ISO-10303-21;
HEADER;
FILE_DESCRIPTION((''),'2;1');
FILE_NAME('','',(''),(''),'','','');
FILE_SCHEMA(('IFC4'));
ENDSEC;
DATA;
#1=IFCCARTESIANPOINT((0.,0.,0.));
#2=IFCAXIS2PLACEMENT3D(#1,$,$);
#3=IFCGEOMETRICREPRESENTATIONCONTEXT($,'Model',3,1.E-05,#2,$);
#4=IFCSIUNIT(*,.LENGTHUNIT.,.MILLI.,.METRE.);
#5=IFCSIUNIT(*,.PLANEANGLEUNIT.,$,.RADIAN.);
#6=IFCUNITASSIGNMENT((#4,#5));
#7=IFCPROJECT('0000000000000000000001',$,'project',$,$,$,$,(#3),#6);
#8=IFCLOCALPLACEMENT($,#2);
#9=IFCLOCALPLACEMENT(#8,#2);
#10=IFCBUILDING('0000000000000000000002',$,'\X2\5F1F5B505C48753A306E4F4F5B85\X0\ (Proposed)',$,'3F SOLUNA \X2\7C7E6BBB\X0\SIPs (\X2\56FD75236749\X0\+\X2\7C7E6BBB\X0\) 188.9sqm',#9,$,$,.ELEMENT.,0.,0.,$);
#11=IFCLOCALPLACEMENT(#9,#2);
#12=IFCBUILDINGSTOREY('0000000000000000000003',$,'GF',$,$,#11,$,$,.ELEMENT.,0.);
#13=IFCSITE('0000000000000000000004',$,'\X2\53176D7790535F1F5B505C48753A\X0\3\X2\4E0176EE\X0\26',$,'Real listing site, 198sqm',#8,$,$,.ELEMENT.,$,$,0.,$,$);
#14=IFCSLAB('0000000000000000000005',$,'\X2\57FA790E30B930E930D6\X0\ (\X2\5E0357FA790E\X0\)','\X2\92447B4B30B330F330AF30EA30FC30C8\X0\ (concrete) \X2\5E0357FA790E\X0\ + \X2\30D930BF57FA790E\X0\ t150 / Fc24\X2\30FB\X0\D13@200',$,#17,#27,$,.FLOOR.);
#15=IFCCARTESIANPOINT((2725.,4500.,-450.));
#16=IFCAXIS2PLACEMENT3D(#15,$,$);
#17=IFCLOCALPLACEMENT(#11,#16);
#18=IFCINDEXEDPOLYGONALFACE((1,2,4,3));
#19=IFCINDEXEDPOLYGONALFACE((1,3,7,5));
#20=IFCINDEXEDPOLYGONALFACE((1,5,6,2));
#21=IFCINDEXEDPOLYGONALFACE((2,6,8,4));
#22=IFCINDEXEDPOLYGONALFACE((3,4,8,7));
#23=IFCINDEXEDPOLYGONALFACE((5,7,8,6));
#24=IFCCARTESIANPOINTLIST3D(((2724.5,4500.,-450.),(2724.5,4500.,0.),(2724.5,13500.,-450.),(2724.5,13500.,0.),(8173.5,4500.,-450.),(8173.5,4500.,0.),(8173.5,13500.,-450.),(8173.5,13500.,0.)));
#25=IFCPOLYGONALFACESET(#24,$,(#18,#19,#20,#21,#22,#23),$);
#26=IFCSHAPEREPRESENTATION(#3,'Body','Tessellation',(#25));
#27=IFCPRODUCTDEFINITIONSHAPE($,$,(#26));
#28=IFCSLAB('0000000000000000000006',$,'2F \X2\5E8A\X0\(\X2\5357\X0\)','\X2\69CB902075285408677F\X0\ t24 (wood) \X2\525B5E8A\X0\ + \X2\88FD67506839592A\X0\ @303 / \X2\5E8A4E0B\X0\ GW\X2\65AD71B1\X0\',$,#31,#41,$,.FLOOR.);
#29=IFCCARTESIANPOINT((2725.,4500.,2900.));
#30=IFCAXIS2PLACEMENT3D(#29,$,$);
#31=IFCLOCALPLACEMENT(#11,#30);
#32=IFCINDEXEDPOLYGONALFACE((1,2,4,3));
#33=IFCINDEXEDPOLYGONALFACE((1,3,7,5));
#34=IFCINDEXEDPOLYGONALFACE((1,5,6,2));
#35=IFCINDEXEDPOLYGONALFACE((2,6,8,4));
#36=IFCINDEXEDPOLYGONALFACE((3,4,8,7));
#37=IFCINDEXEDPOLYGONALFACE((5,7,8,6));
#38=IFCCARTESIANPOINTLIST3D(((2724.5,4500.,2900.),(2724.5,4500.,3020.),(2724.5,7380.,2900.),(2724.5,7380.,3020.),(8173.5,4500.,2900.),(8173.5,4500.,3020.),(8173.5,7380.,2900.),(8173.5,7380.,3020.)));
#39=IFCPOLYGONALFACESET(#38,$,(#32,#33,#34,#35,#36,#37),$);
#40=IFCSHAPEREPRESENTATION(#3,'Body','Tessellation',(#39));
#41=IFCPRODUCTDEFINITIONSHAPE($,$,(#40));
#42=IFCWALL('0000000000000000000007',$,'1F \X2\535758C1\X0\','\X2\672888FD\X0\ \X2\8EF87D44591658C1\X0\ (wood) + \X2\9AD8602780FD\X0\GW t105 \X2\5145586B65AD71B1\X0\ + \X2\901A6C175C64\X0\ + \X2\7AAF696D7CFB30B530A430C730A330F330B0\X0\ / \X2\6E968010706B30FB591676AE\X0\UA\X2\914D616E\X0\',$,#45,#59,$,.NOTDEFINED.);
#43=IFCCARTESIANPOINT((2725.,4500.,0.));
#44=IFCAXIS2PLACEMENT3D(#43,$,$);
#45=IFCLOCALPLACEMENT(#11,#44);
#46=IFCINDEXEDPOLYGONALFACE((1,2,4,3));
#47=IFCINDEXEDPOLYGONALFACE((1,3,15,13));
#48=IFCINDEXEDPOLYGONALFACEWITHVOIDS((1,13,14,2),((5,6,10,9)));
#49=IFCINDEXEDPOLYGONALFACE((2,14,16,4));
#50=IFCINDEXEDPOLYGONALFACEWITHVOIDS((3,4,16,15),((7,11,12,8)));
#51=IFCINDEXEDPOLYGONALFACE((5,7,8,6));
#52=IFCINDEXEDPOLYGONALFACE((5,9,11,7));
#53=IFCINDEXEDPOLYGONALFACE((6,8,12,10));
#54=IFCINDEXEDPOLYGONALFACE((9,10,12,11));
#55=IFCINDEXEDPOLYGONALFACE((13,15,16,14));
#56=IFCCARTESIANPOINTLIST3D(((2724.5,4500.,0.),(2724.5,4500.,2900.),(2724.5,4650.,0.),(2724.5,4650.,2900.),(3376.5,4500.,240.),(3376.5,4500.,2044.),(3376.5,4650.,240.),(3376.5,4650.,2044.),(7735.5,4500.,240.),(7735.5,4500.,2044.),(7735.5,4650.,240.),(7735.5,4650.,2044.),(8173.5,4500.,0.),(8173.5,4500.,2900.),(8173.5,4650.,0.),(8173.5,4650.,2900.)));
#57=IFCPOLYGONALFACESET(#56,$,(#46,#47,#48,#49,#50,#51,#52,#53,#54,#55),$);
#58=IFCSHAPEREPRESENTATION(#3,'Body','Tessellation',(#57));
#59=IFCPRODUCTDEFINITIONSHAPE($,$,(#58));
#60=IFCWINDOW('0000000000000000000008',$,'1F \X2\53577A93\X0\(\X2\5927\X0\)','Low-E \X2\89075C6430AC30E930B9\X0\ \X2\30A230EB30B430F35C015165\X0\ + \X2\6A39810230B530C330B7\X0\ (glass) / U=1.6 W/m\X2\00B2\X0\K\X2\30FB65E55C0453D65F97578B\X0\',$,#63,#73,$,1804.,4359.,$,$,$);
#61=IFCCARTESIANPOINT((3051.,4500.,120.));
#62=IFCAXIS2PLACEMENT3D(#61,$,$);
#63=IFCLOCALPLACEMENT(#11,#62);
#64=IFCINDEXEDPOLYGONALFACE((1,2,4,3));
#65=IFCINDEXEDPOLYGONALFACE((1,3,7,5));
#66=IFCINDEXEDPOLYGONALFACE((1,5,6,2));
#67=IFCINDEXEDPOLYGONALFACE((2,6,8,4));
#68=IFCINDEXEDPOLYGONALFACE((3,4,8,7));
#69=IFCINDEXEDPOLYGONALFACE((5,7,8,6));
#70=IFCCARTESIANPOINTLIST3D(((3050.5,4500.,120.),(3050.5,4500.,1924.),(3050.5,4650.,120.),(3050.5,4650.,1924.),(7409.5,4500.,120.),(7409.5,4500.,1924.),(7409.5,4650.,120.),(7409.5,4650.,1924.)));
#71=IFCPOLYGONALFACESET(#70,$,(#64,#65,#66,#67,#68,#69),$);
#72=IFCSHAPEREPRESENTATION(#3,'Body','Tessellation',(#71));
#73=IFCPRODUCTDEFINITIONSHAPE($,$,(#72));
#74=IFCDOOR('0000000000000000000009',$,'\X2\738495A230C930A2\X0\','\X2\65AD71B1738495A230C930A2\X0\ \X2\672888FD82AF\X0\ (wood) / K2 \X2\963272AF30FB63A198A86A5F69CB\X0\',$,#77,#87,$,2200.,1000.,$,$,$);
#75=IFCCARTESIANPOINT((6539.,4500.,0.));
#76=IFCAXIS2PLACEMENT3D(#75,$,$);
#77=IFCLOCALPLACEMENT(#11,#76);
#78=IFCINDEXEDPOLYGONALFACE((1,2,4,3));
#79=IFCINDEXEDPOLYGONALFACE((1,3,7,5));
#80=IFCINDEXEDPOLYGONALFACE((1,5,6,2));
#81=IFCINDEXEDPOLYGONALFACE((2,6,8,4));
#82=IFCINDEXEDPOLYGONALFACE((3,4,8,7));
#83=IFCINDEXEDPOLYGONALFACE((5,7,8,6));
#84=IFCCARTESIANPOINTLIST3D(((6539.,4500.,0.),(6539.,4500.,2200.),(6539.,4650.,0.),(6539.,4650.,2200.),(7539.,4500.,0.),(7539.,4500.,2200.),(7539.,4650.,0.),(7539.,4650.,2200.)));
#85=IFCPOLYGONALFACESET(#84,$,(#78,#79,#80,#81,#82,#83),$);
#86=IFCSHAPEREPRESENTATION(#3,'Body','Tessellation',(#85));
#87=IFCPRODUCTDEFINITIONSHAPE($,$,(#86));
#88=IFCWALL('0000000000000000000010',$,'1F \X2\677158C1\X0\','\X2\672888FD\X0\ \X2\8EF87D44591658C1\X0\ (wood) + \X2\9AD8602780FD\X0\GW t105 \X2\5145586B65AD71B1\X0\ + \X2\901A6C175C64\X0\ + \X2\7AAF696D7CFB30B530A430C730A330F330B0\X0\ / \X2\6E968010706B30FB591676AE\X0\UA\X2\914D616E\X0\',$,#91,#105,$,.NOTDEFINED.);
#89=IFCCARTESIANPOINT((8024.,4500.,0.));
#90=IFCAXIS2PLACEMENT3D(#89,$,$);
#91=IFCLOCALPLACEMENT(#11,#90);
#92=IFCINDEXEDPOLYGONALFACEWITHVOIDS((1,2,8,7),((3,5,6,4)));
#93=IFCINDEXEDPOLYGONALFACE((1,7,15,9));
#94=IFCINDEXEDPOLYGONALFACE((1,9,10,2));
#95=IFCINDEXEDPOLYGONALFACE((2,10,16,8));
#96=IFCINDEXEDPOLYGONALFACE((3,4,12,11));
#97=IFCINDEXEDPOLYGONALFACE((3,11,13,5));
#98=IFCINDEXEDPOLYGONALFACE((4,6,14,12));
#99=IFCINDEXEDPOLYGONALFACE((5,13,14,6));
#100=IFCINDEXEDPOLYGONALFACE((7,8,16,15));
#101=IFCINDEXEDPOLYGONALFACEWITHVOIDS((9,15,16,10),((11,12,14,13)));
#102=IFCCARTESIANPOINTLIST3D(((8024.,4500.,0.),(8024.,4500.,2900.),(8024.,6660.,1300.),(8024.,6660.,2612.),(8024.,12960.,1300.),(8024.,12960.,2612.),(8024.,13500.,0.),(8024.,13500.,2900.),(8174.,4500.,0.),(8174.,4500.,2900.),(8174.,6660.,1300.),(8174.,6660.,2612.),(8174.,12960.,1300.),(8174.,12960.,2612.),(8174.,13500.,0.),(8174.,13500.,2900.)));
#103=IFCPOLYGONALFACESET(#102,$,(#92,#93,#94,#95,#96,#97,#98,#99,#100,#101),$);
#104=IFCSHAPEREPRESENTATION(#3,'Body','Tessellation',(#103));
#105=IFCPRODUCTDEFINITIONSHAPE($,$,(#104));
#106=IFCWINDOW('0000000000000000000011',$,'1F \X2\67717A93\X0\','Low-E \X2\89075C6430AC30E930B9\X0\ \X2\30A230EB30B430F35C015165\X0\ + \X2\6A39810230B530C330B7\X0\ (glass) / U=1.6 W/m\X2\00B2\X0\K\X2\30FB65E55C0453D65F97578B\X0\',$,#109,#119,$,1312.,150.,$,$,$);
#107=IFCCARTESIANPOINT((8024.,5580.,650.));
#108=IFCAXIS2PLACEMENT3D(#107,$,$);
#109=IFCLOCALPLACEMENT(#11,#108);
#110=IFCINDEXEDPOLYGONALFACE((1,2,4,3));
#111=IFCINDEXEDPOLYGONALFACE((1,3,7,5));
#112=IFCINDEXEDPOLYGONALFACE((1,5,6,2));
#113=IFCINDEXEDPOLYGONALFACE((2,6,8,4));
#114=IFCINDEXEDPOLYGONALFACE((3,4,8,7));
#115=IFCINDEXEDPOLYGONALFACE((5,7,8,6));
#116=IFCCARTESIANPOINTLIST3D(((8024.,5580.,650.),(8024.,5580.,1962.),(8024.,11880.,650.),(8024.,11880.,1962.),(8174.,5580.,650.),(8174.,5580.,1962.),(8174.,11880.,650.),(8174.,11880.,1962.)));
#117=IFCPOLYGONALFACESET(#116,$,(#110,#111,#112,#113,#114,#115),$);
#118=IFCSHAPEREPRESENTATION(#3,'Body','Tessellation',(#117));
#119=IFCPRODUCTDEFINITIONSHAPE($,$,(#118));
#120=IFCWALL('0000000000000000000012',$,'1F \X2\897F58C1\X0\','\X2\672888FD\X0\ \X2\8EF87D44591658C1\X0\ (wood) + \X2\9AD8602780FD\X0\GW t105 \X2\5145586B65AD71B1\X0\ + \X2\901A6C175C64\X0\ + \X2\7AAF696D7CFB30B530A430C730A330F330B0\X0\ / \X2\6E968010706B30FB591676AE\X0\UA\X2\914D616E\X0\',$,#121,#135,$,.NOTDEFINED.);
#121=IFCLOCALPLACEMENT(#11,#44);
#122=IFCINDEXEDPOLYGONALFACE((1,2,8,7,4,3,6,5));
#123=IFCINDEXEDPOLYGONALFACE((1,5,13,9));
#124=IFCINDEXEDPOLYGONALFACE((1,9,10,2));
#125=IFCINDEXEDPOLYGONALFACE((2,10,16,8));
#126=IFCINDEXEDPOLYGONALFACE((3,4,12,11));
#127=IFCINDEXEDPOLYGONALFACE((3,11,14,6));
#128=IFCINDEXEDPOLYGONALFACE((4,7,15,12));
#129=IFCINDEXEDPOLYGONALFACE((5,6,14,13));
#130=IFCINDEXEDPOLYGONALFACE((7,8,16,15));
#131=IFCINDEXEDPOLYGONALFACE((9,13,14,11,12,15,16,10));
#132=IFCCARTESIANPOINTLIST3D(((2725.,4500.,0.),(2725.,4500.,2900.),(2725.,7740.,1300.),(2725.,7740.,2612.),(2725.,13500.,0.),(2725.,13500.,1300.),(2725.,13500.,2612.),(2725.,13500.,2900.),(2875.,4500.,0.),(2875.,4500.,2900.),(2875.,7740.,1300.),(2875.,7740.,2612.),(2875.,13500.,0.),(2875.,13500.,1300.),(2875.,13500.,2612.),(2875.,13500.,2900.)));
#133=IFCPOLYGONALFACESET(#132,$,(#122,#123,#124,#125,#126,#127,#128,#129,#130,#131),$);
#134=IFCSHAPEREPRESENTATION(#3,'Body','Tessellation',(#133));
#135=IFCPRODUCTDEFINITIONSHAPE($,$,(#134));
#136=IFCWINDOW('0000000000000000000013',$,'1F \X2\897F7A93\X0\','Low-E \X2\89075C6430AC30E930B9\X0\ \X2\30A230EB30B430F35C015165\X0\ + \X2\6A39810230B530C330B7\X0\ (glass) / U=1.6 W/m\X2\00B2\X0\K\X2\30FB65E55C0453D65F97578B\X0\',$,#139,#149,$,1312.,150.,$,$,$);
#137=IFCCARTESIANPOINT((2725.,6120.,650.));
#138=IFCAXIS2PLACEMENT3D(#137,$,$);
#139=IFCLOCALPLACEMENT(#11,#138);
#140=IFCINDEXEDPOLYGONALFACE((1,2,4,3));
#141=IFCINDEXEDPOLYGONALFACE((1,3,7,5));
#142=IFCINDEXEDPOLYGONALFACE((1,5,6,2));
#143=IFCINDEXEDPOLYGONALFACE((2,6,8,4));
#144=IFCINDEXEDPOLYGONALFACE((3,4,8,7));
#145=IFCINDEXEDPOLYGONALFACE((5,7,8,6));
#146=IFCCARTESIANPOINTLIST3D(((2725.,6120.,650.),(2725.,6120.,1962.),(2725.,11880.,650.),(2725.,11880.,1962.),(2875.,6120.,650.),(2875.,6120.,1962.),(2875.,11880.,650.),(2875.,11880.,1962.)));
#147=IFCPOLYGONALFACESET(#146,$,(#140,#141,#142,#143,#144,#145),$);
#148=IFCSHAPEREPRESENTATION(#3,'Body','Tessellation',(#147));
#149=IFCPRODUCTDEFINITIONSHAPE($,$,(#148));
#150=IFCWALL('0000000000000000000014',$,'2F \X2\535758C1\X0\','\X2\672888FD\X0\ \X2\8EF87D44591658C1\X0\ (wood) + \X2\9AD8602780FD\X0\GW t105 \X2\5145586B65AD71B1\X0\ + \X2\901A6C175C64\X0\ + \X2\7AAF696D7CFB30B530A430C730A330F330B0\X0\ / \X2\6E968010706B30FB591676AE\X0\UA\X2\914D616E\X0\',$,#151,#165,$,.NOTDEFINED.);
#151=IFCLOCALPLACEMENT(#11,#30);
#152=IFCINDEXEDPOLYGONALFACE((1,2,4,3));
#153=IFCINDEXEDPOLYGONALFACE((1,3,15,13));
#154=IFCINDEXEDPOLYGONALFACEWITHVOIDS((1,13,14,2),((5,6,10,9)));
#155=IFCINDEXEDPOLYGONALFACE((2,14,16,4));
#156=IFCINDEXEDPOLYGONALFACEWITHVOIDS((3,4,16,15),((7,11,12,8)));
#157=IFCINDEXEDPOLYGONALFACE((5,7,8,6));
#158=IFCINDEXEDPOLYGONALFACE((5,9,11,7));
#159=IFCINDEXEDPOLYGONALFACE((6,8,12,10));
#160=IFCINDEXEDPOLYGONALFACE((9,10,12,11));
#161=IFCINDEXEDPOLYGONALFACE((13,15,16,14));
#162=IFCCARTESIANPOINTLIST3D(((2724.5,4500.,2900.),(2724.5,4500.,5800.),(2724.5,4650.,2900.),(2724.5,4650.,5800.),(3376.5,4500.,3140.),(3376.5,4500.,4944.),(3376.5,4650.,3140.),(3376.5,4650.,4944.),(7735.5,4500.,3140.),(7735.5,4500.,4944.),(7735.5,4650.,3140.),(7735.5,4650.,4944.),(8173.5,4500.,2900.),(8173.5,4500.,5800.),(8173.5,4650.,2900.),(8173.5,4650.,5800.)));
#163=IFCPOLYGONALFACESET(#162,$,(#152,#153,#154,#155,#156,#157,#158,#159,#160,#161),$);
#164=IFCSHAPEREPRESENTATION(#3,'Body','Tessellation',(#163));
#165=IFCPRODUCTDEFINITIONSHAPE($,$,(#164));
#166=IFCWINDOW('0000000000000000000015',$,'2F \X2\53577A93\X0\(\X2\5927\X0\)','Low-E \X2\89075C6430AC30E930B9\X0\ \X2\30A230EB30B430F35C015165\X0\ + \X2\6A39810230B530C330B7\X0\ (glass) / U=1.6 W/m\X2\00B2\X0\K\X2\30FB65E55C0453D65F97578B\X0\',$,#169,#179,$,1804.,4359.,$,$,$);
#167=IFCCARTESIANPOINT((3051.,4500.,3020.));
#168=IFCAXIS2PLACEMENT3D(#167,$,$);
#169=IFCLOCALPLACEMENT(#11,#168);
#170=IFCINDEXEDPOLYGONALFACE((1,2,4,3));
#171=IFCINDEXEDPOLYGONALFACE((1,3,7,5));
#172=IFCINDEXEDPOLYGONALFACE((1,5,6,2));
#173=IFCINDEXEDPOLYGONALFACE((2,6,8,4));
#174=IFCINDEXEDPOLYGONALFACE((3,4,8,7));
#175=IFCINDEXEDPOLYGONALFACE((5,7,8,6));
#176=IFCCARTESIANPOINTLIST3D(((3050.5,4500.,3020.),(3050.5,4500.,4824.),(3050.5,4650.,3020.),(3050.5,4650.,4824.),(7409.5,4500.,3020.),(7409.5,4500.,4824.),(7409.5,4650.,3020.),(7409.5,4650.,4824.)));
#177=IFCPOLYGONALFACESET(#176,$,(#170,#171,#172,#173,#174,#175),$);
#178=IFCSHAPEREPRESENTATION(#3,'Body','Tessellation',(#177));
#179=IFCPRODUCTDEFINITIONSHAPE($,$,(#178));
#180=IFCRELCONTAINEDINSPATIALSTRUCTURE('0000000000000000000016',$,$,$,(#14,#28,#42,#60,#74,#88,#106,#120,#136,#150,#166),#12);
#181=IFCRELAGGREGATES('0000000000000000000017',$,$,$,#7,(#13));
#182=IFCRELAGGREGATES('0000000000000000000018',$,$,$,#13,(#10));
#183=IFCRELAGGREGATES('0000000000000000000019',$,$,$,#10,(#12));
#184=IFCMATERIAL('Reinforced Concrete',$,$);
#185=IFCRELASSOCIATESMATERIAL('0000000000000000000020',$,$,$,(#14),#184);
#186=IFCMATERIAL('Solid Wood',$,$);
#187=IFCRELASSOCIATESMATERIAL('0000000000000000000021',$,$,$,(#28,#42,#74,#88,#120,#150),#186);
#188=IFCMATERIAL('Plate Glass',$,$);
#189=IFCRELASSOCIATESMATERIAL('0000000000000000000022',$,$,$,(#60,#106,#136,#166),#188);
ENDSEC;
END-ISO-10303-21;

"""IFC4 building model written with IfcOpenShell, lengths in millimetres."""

from ifc_helpers import new_model, si_unit, frame, frame_2d, origin, place, context, project, spatial, rectangle, extrude, material, element, fill, save


model = new_model("IFC4")

# Units and contexts
model_context = context("Model", 3, precision=1e-05, world=origin())
ifc_project = project(units=[si_unit("LENGTHUNIT", "METRE", prefix="MILLI"), si_unit("PLANEANGLEUNIT", "RADIAN")], contexts=[model_context])

# Site, building, storey
site_placement = place(None, origin())
site = spatial("IfcSite", under=ifc_project, at=site_placement, Name="北海道弟子屈町3丁目26", ObjectType="Real listing site, 198sqm", CompositionType="ELEMENT", RefElevation=0.0)
building_placement = place(site_placement, origin())
building = spatial("IfcBuilding", under=site, at=building_placement, Name="弟子屈町の住宅 (Proposed)", ObjectType="3F SOLUNA 籾殻SIPs (国産杉+籾殻) 188.9sqm", CompositionType="ELEMENT", ElevationOfRefHeight=0.0, ElevationOfTerrain=0.0)
storey_placement = place(building_placement, origin())
storey = spatial("IfcBuildingStorey", under=building, at=storey_placement, Name="GF", CompositionType="ELEMENT", Elevation=0.0)

# Slabs
ifc_material_1 = material(Name="Reinforced Concrete")
slab_1_placement = place(storey_placement, frame((2725.0, 4500.0, -450.0)))
element("IfcSlab", 1, at=slab_1_placement, inside=storey, material=ifc_material_1, Name="基礎スラブ (布基礎)", Description="鉄筋コンクリート (concrete) 布基礎 + ベタ基礎 t150 / Fc24・D13@200", PredefinedType="FLOOR", context=model_context, shape_type="SweptSolid", body=[
    extrude(rectangle(XDim=5449.0, YDim=9000.0, at=frame_2d((2724.0, 4500.0))), frame((2725.0, 4500.0, -450.0)), (0.0, 0.0, 1.0), 450.0),
])
ifc_material_2 = material(Name="Solid Wood")
slab_2_placement = place(storey_placement, frame((2725.0, 4500.0, 2900.0)))
element("IfcSlab", 2, at=slab_2_placement, inside=storey, material=ifc_material_2, Name="2F 床(南)", Description="構造用合板 t24 (wood) 剛床 + 製材根太 @303 / 床下 GW断熱", PredefinedType="FLOOR", context=model_context, shape_type="SweptSolid", body=[
    extrude(rectangle(XDim=5449.0, YDim=2880.0, at=frame_2d((2724.0, 1440.0))), frame((2725.0, 4500.0, 2900.0)), (0.0, 0.0, 1.0), 120.0),
])

# Wall, openings, window, door
wall_1_placement = place(storey_placement, frame((2725.0, 4500.0, 0.0)))
wall_1 = element("IfcWall", 3, at=wall_1_placement, inside=storey, material=ifc_material_2, Name="1F 南壁", Description="木製 軸組外壁 (wood) + 高性能GW t105 充填断熱 + 通気層 + 窯業系サイディング / 準耐火・外皮UA配慮", PredefinedType="NOTDEFINED", context=model_context, shape_type="SweptSolid", body=[
    extrude(rectangle(XDim=5449.0, YDim=150.0, at=frame_2d((2724.0, 75.0))), frame((2725.0, 4500.0, 0.0)), (0.0, 0.0, 1.0), 2900.0),
])
opening_1_placement = place(storey_placement, frame((3051.0, 4500.0, 120.0)))
opening_1 = element("IfcOpeningElement", 4, at=opening_1_placement, cuts=wall_1, PredefinedType="NOTDEFINED", context=model_context, shape_type="SweptSolid", body=[
    extrude(rectangle(XDim=4359.0, YDim=150.0, at=frame_2d((2179.0, 75.0))), frame((3051.0, 4500.0, 120.0)), (0.0, 0.0, 1.0), 1804.0),
])
opening_2_placement = place(storey_placement, frame((6539.0, 4500.0, 0.0)))
opening_2 = element("IfcOpeningElement", 5, at=opening_2_placement, cuts=wall_1, PredefinedType="NOTDEFINED", context=model_context, shape_type="SweptSolid", body=[
    extrude(rectangle(XDim=1000.0, YDim=150.0, at=frame_2d((500.0, 75.0))), frame((6539.0, 4500.0, 0.0)), (0.0, 0.0, 1.0), 2200.0),
])
ifc_material_3 = material(Name="Plate Glass")
window_1_placement = place(storey_placement, frame((3051.0, 4500.0, 120.0)))
window_1 = element("IfcWindow", 6, at=window_1_placement, inside=storey, material=ifc_material_3, Name="1F 南窓(大)", Description="Low-E 複層ガラス アルゴン封入 + 樹脂サッシ (glass) / U=1.6 W/m²K・日射取得型", OverallHeight=1804.0, OverallWidth=4359.0, context=model_context, shape_type="SweptSolid", body=[
    extrude(rectangle(XDim=4359.0, YDim=150.0, at=frame_2d((2179.0, 75.0))), frame((3051.0, 4500.0, 120.0)), (0.0, 0.0, 1.0), 1804.0),
])
fill(opening_1, window_1)
door_placement = place(storey_placement, frame((6539.0, 4500.0, 0.0)))
door = element("IfcDoor", 7, at=door_placement, inside=storey, material=ifc_material_2, Name="玄関ドア", Description="断熱玄関ドア 木製芯 (wood) / K2 防犯・採風機構", OverallHeight=2200.0, OverallWidth=1000.0, context=model_context, shape_type="SweptSolid", body=[
    extrude(rectangle(XDim=1000.0, YDim=150.0, at=frame_2d((500.0, 75.0))), frame((6539.0, 4500.0, 0.0)), (0.0, 0.0, 1.0), 2200.0),
])
fill(opening_2, door)

# Walls, openings, windows
wall_2_placement = place(storey_placement, frame((8024.0, 4500.0, 0.0)))
wall_2 = element("IfcWall", 8, at=wall_2_placement, inside=storey, material=ifc_material_2, Name="1F 東壁", Description="木製 軸組外壁 (wood) + 高性能GW t105 充填断熱 + 通気層 + 窯業系サイディング / 準耐火・外皮UA配慮", PredefinedType="NOTDEFINED", context=model_context, shape_type="SweptSolid", body=[
    extrude(rectangle(XDim=150.0, YDim=9000.0, at=frame_2d((75.0, 4500.0))), frame((8024.0, 4500.0, 0.0)), (0.0, 0.0, 1.0), 2900.0),
])
opening_3_placement = place(storey_placement, frame((8024.0, 5580.0, 650.0)))
opening_3 = element("IfcOpeningElement", 9, at=opening_3_placement, cuts=wall_2, PredefinedType="NOTDEFINED", context=model_context, shape_type="SweptSolid", body=[
    extrude(rectangle(XDim=150.0, YDim=6300.0, at=frame_2d((75.0, 3150.0))), frame((8024.0, 5580.0, 650.0)), (0.0, 0.0, 1.0), 1312.0),
])
window_2_placement = place(storey_placement, frame((8024.0, 5580.0, 650.0)))
window_2 = element("IfcWindow", 10, at=window_2_placement, inside=storey, material=ifc_material_3, Name="1F 東窓", Description="Low-E 複層ガラス アルゴン封入 + 樹脂サッシ (glass) / U=1.6 W/m²K・日射取得型", OverallHeight=1312.0, OverallWidth=150.0, context=model_context, shape_type="SweptSolid", body=[
    extrude(rectangle(XDim=150.0, YDim=6300.0, at=frame_2d((75.0, 3150.0))), frame((8024.0, 5580.0, 650.0)), (0.0, 0.0, 1.0), 1312.0),
])
fill(opening_3, window_2)
wall_3_placement = place(storey_placement, frame((2725.0, 4500.0, 0.0)))
wall_3 = element("IfcWall", 11, at=wall_3_placement, inside=storey, material=ifc_material_2, Name="1F 西壁", Description="木製 軸組外壁 (wood) + 高性能GW t105 充填断熱 + 通気層 + 窯業系サイディング / 準耐火・外皮UA配慮", PredefinedType="NOTDEFINED", context=model_context, shape_type="SweptSolid", body=[
    extrude(rectangle(XDim=150.0, YDim=9000.0, at=frame_2d((75.0, 4500.0))), frame((2725.0, 4500.0, 0.0)), (0.0, 0.0, 1.0), 2900.0),
])
opening_4_placement = place(storey_placement, frame((2725.0, 6120.0, 650.0)))
opening_4 = element("IfcOpeningElement", 12, at=opening_4_placement, cuts=wall_3, PredefinedType="NOTDEFINED", context=model_context, shape_type="SweptSolid", body=[
    extrude(rectangle(XDim=150.0, YDim=5760.0, at=frame_2d((75.0, 2880.0))), frame((2725.0, 6120.0, 650.0)), (0.0, 0.0, 1.0), 1312.0),
])
window_3_placement = place(storey_placement, frame((2725.0, 6120.0, 650.0)))
window_3 = element("IfcWindow", 13, at=window_3_placement, inside=storey, material=ifc_material_3, Name="1F 西窓", Description="Low-E 複層ガラス アルゴン封入 + 樹脂サッシ (glass) / U=1.6 W/m²K・日射取得型", OverallHeight=1312.0, OverallWidth=150.0, context=model_context, shape_type="SweptSolid", body=[
    extrude(rectangle(XDim=150.0, YDim=5760.0, at=frame_2d((75.0, 2880.0))), frame((2725.0, 6120.0, 650.0)), (0.0, 0.0, 1.0), 1312.0),
])
fill(opening_4, window_3)

# Wall, opening, window
wall_4_placement = place(storey_placement, frame((2725.0, 4500.0, 2900.0)))
wall_4 = element("IfcWall", 14, at=wall_4_placement, inside=storey, material=ifc_material_2, Name="2F 南壁", Description="木製 軸組外壁 (wood) + 高性能GW t105 充填断熱 + 通気層 + 窯業系サイディング / 準耐火・外皮UA配慮", PredefinedType="NOTDEFINED", context=model_context, shape_type="SweptSolid", body=[
    extrude(rectangle(XDim=5449.0, YDim=150.0, at=frame_2d((2724.0, 75.0))), frame((2725.0, 4500.0, 2900.0)), (0.0, 0.0, 1.0), 2900.0),
])
opening_5_placement = place(storey_placement, frame((3051.0, 4500.0, 3020.0)))
opening_5 = element("IfcOpeningElement", 15, at=opening_5_placement, cuts=wall_4, PredefinedType="NOTDEFINED", context=model_context, shape_type="SweptSolid", body=[
    extrude(rectangle(XDim=4359.0, YDim=150.0, at=frame_2d((2179.0, 75.0))), frame((3051.0, 4500.0, 3020.0)), (0.0, 0.0, 1.0), 1804.0),
])
window_4_placement = place(storey_placement, frame((3051.0, 4500.0, 3020.0)))
window_4 = element("IfcWindow", 16, at=window_4_placement, inside=storey, material=ifc_material_3, Name="2F 南窓(大)", Description="Low-E 複層ガラス アルゴン封入 + 樹脂サッシ (glass) / U=1.6 W/m²K・日射取得型", OverallHeight=1804.0, OverallWidth=4359.0, context=model_context, shape_type="SweptSolid", body=[
    extrude(rectangle(XDim=4359.0, YDim=150.0, at=frame_2d((2179.0, 75.0))), frame((3051.0, 4500.0, 3020.0)), (0.0, 0.0, 1.0), 1804.0),
])
fill(opening_5, window_4)

save(model, "model.ifc")
